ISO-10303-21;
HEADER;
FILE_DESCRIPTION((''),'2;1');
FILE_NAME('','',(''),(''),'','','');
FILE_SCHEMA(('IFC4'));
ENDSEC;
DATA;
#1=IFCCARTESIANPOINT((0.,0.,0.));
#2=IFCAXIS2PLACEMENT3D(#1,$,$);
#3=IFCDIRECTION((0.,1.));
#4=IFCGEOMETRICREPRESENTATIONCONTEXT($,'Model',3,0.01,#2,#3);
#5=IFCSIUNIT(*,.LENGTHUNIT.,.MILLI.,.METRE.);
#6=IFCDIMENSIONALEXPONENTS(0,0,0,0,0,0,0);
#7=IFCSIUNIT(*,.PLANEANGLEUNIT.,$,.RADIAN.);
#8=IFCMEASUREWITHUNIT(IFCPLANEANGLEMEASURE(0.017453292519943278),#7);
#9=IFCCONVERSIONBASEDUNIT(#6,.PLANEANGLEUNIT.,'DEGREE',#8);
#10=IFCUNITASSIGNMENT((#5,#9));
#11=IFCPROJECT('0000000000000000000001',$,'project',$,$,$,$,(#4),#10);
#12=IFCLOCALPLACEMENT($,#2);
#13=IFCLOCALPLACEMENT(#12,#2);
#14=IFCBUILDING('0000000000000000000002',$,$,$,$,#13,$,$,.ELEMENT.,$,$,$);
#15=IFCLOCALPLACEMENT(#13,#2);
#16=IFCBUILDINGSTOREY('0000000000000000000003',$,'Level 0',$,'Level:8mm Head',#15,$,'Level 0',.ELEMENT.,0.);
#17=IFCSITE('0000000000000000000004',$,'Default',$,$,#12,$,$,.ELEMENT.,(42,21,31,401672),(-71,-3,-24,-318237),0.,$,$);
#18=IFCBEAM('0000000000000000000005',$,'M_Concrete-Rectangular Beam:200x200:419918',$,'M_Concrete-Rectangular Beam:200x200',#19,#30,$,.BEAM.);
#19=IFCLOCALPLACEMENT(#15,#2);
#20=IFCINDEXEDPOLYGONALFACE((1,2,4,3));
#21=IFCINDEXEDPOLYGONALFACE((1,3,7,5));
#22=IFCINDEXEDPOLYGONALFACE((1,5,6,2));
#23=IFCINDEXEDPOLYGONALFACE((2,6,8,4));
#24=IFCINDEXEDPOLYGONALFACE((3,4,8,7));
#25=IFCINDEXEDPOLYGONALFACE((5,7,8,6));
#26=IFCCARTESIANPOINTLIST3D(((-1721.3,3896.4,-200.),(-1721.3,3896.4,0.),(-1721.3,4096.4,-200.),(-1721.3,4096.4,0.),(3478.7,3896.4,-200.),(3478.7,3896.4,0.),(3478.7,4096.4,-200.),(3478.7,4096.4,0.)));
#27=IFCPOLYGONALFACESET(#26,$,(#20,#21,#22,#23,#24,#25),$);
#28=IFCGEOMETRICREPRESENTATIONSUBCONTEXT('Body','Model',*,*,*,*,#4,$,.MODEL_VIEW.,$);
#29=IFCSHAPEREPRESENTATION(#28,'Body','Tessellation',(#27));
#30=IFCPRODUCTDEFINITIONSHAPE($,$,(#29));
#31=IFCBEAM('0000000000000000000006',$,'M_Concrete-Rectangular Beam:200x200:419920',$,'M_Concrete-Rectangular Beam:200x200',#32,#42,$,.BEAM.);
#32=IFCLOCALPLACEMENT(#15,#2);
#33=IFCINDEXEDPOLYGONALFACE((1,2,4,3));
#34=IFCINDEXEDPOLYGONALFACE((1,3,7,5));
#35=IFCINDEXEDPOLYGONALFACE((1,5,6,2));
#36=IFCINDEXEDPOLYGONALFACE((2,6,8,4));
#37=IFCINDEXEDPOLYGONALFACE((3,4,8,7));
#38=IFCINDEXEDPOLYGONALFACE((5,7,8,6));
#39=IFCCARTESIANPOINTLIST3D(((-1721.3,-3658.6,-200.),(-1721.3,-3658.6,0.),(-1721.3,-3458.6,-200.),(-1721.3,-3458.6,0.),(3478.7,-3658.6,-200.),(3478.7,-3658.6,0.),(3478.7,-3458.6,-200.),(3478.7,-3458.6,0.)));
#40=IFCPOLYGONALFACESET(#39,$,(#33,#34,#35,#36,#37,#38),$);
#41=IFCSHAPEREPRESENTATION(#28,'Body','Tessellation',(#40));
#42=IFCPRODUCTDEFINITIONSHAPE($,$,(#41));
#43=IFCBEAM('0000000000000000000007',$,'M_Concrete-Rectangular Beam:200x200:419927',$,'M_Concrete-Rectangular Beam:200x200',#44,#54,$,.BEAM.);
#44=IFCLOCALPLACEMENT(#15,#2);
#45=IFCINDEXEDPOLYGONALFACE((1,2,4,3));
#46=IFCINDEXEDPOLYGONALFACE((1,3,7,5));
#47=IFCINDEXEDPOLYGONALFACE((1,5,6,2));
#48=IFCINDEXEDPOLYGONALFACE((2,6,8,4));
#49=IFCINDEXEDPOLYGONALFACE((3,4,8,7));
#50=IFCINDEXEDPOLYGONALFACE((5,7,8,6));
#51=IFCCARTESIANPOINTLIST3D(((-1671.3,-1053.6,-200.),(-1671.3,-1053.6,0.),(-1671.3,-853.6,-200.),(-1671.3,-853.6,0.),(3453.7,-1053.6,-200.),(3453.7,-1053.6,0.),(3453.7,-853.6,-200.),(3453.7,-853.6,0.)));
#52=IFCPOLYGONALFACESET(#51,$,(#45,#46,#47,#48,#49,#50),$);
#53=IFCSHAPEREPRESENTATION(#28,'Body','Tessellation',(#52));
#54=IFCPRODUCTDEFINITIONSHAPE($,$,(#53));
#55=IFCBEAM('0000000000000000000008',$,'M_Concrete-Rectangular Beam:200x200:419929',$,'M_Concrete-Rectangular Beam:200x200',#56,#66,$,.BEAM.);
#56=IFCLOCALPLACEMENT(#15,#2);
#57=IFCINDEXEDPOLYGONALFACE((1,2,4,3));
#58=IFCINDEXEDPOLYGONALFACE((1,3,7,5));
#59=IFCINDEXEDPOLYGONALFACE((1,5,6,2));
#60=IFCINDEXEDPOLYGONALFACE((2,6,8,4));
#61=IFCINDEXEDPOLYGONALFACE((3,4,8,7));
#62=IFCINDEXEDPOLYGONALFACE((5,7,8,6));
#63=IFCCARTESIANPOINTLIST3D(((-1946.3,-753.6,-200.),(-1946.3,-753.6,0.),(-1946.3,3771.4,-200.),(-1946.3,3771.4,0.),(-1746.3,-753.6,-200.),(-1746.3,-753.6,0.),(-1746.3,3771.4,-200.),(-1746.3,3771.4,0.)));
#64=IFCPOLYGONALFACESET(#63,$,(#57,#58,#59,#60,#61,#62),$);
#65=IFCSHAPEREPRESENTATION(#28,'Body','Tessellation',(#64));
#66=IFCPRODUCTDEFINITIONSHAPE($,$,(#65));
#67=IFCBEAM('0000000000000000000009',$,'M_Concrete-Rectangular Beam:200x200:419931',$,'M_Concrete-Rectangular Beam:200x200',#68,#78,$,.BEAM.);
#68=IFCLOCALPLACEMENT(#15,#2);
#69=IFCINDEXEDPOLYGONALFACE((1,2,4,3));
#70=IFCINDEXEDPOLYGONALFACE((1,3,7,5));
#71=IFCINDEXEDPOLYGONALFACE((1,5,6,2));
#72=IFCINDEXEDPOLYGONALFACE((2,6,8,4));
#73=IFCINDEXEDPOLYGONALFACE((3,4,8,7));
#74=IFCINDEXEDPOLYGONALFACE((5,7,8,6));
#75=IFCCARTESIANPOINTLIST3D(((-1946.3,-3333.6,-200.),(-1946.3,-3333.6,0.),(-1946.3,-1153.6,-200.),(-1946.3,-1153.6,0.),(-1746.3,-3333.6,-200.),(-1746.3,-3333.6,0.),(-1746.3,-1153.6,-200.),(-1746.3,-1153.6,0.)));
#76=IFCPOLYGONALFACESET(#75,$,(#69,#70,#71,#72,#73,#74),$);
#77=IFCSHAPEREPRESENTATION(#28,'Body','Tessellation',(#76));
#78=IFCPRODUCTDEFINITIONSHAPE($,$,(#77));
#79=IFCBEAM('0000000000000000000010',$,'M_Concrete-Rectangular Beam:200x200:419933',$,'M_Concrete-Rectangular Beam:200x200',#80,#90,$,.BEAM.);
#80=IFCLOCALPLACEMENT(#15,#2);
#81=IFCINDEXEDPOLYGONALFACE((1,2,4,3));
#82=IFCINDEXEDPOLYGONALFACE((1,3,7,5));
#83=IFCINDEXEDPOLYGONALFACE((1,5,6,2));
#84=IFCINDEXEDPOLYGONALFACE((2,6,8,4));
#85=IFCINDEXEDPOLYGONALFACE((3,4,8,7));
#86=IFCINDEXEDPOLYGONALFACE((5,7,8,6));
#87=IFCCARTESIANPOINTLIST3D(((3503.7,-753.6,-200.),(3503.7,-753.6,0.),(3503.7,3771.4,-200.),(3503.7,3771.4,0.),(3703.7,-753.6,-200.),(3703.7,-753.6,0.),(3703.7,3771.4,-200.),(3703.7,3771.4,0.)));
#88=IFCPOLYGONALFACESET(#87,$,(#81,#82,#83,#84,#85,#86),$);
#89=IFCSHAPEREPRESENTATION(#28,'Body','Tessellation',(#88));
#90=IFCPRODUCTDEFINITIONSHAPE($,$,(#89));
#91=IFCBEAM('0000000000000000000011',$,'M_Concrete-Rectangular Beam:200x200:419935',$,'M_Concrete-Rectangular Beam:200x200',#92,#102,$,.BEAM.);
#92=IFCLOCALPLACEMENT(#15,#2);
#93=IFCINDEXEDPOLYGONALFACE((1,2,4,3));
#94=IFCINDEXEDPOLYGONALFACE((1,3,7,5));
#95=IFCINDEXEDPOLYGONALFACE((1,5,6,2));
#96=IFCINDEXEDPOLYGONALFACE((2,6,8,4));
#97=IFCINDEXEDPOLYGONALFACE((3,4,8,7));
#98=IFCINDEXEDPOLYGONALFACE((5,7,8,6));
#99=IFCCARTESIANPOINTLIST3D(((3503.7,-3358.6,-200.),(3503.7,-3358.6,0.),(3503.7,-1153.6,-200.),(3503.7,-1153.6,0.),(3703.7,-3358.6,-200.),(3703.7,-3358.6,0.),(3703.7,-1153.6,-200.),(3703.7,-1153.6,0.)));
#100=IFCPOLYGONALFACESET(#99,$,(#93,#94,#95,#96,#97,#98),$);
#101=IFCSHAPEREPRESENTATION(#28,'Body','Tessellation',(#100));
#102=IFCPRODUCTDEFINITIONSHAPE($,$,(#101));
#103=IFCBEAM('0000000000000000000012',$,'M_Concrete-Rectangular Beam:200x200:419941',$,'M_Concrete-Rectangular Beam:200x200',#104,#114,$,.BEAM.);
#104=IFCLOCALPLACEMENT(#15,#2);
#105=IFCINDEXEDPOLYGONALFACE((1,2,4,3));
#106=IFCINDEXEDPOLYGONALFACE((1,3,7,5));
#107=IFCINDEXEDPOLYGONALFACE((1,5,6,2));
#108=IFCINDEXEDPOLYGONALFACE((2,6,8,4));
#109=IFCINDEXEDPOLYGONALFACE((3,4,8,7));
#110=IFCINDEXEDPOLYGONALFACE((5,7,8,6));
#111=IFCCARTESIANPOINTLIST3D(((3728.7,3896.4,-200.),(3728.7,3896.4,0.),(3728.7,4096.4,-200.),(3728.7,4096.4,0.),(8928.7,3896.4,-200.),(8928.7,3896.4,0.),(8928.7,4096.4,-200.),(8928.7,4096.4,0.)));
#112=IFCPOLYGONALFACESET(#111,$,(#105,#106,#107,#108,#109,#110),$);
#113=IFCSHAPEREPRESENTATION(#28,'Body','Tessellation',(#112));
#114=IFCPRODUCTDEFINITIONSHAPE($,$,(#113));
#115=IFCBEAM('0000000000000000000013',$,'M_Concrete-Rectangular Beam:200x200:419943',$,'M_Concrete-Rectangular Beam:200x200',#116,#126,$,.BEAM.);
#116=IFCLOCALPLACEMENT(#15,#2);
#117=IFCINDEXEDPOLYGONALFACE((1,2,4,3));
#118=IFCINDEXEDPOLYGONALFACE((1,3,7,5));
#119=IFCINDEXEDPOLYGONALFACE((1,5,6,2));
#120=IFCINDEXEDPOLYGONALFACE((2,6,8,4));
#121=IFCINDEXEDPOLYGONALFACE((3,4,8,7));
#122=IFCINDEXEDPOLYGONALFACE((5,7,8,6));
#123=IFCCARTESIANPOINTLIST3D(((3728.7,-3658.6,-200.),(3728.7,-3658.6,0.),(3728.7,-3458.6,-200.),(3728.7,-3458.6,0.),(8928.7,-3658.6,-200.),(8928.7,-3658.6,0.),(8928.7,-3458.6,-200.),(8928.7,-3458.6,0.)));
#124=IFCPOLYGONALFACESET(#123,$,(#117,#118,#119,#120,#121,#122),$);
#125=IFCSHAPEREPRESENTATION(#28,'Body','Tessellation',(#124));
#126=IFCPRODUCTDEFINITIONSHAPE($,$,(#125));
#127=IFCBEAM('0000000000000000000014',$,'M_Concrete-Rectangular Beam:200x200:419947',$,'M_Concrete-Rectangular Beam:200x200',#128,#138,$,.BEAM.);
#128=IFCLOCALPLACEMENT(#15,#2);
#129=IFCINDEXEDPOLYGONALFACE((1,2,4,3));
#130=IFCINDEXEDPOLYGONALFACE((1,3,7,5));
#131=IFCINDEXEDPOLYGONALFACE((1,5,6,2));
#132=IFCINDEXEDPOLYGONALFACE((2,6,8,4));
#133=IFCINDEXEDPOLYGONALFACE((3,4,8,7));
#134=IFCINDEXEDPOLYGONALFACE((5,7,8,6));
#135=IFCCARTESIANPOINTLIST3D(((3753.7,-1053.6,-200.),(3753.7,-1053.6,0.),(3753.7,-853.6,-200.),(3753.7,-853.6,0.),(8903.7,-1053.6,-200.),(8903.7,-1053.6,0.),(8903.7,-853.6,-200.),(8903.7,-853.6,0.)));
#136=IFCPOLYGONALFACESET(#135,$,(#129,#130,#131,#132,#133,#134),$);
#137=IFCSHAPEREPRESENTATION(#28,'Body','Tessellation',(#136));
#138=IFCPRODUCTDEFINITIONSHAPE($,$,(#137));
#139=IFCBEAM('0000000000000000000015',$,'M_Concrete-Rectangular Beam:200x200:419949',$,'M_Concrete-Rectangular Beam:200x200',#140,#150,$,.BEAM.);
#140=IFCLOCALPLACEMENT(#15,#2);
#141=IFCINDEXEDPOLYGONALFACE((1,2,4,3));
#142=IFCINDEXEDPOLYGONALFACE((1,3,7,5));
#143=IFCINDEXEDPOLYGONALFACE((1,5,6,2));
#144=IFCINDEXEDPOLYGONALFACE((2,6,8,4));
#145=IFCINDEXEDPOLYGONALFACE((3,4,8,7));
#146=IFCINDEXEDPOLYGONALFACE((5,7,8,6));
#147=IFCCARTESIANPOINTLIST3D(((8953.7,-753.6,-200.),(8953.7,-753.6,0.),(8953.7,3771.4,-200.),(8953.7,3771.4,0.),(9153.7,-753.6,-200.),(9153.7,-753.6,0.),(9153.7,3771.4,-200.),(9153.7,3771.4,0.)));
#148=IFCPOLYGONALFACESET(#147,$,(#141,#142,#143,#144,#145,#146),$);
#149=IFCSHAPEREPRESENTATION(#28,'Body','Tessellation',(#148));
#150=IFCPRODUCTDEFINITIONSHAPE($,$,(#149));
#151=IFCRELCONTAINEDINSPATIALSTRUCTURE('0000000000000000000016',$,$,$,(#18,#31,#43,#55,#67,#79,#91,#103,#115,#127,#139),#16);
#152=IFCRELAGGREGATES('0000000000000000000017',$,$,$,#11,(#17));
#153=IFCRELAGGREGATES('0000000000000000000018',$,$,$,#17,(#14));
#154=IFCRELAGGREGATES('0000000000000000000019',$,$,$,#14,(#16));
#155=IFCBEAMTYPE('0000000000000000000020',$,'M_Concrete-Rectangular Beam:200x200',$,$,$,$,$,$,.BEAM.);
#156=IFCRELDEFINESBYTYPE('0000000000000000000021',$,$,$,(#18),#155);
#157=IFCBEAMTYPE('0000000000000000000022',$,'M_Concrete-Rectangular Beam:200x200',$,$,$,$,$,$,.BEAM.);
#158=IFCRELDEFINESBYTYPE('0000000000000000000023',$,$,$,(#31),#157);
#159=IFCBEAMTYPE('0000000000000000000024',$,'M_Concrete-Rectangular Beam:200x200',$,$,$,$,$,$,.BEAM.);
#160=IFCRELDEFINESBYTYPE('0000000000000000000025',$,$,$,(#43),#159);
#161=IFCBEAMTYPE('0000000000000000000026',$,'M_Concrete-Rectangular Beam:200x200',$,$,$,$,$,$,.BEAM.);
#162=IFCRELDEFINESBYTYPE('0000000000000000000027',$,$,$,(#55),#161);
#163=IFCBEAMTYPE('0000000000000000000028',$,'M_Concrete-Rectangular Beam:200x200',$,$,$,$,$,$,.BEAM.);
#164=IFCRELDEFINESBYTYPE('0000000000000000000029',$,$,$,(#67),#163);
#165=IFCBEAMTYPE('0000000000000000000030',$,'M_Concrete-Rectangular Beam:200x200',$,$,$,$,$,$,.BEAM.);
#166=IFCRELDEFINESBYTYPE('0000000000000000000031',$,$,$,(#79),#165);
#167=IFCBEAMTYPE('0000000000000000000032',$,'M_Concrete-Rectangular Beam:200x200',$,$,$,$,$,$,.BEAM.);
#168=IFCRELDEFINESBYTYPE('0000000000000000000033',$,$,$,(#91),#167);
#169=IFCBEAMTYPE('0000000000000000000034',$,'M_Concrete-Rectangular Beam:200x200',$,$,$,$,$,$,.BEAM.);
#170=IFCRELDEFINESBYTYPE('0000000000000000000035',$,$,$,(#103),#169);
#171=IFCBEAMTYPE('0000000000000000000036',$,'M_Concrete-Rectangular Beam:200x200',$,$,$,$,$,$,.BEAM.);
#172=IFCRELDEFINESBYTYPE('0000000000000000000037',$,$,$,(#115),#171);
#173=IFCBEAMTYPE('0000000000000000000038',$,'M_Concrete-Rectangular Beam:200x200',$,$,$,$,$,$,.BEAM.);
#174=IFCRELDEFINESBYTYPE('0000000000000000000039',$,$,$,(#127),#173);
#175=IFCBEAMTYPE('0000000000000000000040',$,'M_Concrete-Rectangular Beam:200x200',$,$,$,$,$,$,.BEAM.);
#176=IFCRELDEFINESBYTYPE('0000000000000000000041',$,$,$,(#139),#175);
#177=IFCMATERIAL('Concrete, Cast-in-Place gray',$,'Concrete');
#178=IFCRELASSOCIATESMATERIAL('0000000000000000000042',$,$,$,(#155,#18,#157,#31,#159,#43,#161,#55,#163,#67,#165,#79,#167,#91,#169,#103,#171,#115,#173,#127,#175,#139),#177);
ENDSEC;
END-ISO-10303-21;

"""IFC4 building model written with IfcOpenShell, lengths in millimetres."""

from ifc_helpers import new_model, entity, si_unit, converted_unit, direction, frame, origin, place, context, subcontext, project, spatial, indexed_curve, outline, extrude, source, transform, mapped, material, type_object, type_shapes, element, save


model = new_model("IFC4")

# Units and contexts
model_context = context("Model", 3, precision=0.01, world=origin(), true_north=direction((0.0, 1.0)))
body_context = subcontext(model_context, "Body", "Model", "MODEL_VIEW")
ifc_project = project(units=[si_unit("LENGTHUNIT", "METRE", prefix="MILLI"), converted_unit("PLANEANGLEUNIT", "DEGREE", entity("IfcPlaneAngleMeasure", 0.017453292519943278), si_unit("PLANEANGLEUNIT", "RADIAN"), dimensions=[0, 0, 0, 0, 0, 0, 0])], contexts=[model_context])

# Site, building, storey
site_placement = place(None, origin())
site = spatial("IfcSite", under=ifc_project, at=site_placement, Name="Default", CompositionType="ELEMENT", RefLatitude=(42, 21, 31, 401672), RefLongitude=(-71, -3, -24, -318237), RefElevation=0.0)
building_placement = place(site_placement, origin())
building = spatial("IfcBuilding", under=site, at=building_placement, CompositionType="ELEMENT")
storey_placement = place(building_placement, origin())
storey = spatial("IfcBuildingStorey", under=building, at=storey_placement, Name="Level 0", ObjectType="Level:8mm Head", LongName="Level 0", CompositionType="ELEMENT", Elevation=0.0)

# Beams
ifc_material = material(Name="Concrete, Cast-in-Place gray", Category="Concrete")
beam_type_1 = type_object("IfcBeamType", Name="M_Concrete-Rectangular Beam:200x200", PredefinedType="BEAM", material=ifc_material)
shared_shape_1 = source(origin(), body_context, "Body", "SweptSolid", [
    extrude(outline(indexed_curve([(-100.0, -100.0), (100.0, -100.0), (100.0, 100.0), (-100.0, 100.0), (-100.0, -100.0)], self_intersect=False)), frame((-1721.3, 3996.4, -100.0), z_axis=(1.0, 0.0, 0.0), x_axis=(0.0, 0.0, -1.0)), (0.0, 0.0, 1.0), 5200.0),
])
type_shapes(beam_type_1, [shared_shape_1])
beam_1_placement = place(storey_placement, origin())
element("IfcBeam", 1, at=beam_1_placement, inside=storey, type_object=beam_type_1, material=ifc_material, Name="M_Concrete-Rectangular Beam:200x200:419918", ObjectType="M_Concrete-Rectangular Beam:200x200", PredefinedType="BEAM", context=body_context, shape_type="MappedRepresentation", body=[
    mapped(shared_shape_1, transform((0.0, 0.0, 0.0), scale=1.0)),
])
beam_type_2 = type_object("IfcBeamType", Name="M_Concrete-Rectangular Beam:200x200", PredefinedType="BEAM", material=ifc_material)
shared_shape_2 = source(origin(), body_context, "Body", "SweptSolid", [
    extrude(outline(indexed_curve([(-100.0, -100.0), (100.0, -100.0), (100.0, 100.0), (-100.0, 100.0), (-100.0, -100.0)], self_intersect=False)), frame((-1721.3, -3558.6, -100.0), z_axis=(1.0, 0.0, 0.0), x_axis=(0.0, 0.0, -1.0)), (0.0, 0.0, 1.0), 5200.0),
])
type_shapes(beam_type_2, [shared_shape_2])
beam_2_placement = place(storey_placement, origin())
element("IfcBeam", 2, at=beam_2_placement, inside=storey, type_object=beam_type_2, material=ifc_material, Name="M_Concrete-Rectangular Beam:200x200:419920", ObjectType="M_Concrete-Rectangular Beam:200x200", PredefinedType="BEAM", context=body_context, shape_type="MappedRepresentation", body=[
    mapped(shared_shape_2, transform((0.0, 0.0, 0.0), scale=1.0)),
])
beam_type_3 = type_object("IfcBeamType", Name="M_Concrete-Rectangular Beam:200x200", PredefinedType="BEAM", material=ifc_material)
shared_shape_3 = source(origin(), body_context, "Body", "SweptSolid", [
    extrude(outline(indexed_curve([(-100.0, -100.0), (100.0, -100.0), (100.0, 100.0), (-100.0, 100.0), (-100.0, -100.0)], self_intersect=False)), frame((-1671.3, -953.6, -100.0), z_axis=(1.0, 0.0, 0.0), x_axis=(0.0, 0.0, -1.0)), (0.0, 0.0, 1.0), 5125.0),
])
type_shapes(beam_type_3, [shared_shape_3])
beam_3_placement = place(storey_placement, origin())
element("IfcBeam", 3, at=beam_3_placement, inside=storey, type_object=beam_type_3, material=ifc_material, Name="M_Concrete-Rectangular Beam:200x200:419927", ObjectType="M_Concrete-Rectangular Beam:200x200", PredefinedType="BEAM", context=body_context, shape_type="MappedRepresentation", body=[
    mapped(shared_shape_3, transform((0.0, 0.0, 0.0), scale=1.0)),
])
beam_type_4 = type_object("IfcBeamType", Name="M_Concrete-Rectangular Beam:200x200", PredefinedType="BEAM", material=ifc_material)
shared_shape_4 = source(origin(), body_context, "Body", "SweptSolid", [
    extrude(outline(indexed_curve([(-100.0, -100.0), (100.0, -100.0), (100.0, 100.0), (-100.0, 100.0), (-100.0, -100.0)], self_intersect=False)), frame((-1846.3, 3771.4, -100.0), z_axis=(0.0, -1.0, 0.0), x_axis=(-1.0, 0.0, 0.0)), (0.0, 0.0, 1.0), 4525.0),
])
type_shapes(beam_type_4, [shared_shape_4])
beam_4_placement = place(storey_placement, origin())
element("IfcBeam", 4, at=beam_4_placement, inside=storey, type_object=beam_type_4, material=ifc_material, Name="M_Concrete-Rectangular Beam:200x200:419929", ObjectType="M_Concrete-Rectangular Beam:200x200", PredefinedType="BEAM", context=body_context, shape_type="MappedRepresentation", body=[
    mapped(shared_shape_4, transform((0.0, 0.0, 0.0), scale=1.0)),
])
beam_type_5 = type_object("IfcBeamType", Name="M_Concrete-Rectangular Beam:200x200", PredefinedType="BEAM", material=ifc_material)
shared_shape_5 = source(origin(), body_context, "Body", "SweptSolid", [
    extrude(outline(indexed_curve([(-100.0, -100.0), (100.0, -100.0), (100.0, 100.0), (-100.0, 100.0), (-100.0, -100.0)], self_intersect=False)), frame((-1846.3, -1153.6, -100.0), z_axis=(0.0, -1.0, 0.0), x_axis=(-1.0, 0.0, 0.0)), (0.0, 0.0, 1.0), 2180.0),
])
type_shapes(beam_type_5, [shared_shape_5])
beam_5_placement = place(storey_placement, origin())
element("IfcBeam", 5, at=beam_5_placement, inside=storey, type_object=beam_type_5, material=ifc_material, Name="M_Concrete-Rectangular Beam:200x200:419931", ObjectType="M_Concrete-Rectangular Beam:200x200", PredefinedType="BEAM", context=body_context, shape_type="MappedRepresentation", body=[
    mapped(shared_shape_5, transform((0.0, 0.0, 0.0), scale=1.0)),
])
beam_type_6 = type_object("IfcBeamType", Name="M_Concrete-Rectangular Beam:200x200", PredefinedType="BEAM", material=ifc_material)
shared_shape_6 = source(origin(), body_context, "Body", "SweptSolid", [
    extrude(outline(indexed_curve([(-100.0, -100.0), (100.0, -100.0), (100.0, 100.0), (-100.0, 100.0), (-100.0, -100.0)], self_intersect=False)), frame((3603.7, 3771.4, -100.0), z_axis=(0.0, -1.0, 0.0), x_axis=(-1.0, 0.0, 0.0)), (0.0, 0.0, 1.0), 4525.0),
])
type_shapes(beam_type_6, [shared_shape_6])
beam_6_placement = place(storey_placement, origin())
element("IfcBeam", 6, at=beam_6_placement, inside=storey, type_object=beam_type_6, material=ifc_material, Name="M_Concrete-Rectangular Beam:200x200:419933", ObjectType="M_Concrete-Rectangular Beam:200x200", PredefinedType="BEAM", context=body_context, shape_type="MappedRepresentation", body=[
    mapped(shared_shape_6, transform((0.0, 0.0, 0.0), scale=1.0)),
])
beam_type_7 = type_object("IfcBeamType", Name="M_Concrete-Rectangular Beam:200x200", PredefinedType="BEAM", material=ifc_material)
shared_shape_7 = source(origin(), body_context, "Body", "SweptSolid", [
    extrude(outline(indexed_curve([(-100.0, -100.0), (100.0, -100.0), (100.0, 100.0), (-100.0, 100.0), (-100.0, -100.0)], self_intersect=False)), frame((3603.7, -1153.6, -100.0), z_axis=(0.0, -1.0, 0.0), x_axis=(-1.0, 0.0, 0.0)), (0.0, 0.0, 1.0), 2205.0),
])
type_shapes(beam_type_7, [shared_shape_7])
beam_7_placement = place(storey_placement, origin())
element("IfcBeam", 7, at=beam_7_placement, inside=storey, type_object=beam_type_7, material=ifc_material, Name="M_Concrete-Rectangular Beam:200x200:419935", ObjectType="M_Concrete-Rectangular Beam:200x200", PredefinedType="BEAM", context=body_context, shape_type="MappedRepresentation", body=[
    mapped(shared_shape_7, transform((0.0, 0.0, 0.0), scale=1.0)),
])
beam_type_8 = type_object("IfcBeamType", Name="M_Concrete-Rectangular Beam:200x200", PredefinedType="BEAM", material=ifc_material)
shared_shape_8 = source(origin(), body_context, "Body", "SweptSolid", [
    extrude(outline(indexed_curve([(-100.0, -100.0), (100.0, -100.0), (100.0, 100.0), (-100.0, 100.0), (-100.0, -100.0)], self_intersect=False)), frame((3728.7, 3996.4, -100.0), z_axis=(1.0, 0.0, 0.0), x_axis=(0.0, 0.0, -1.0)), (0.0, 0.0, 1.0), 5200.0),
])
type_shapes(beam_type_8, [shared_shape_8])
beam_8_placement = place(storey_placement, origin())
element("IfcBeam", 8, at=beam_8_placement, inside=storey, type_object=beam_type_8, material=ifc_material, Name="M_Concrete-Rectangular Beam:200x200:419941", ObjectType="M_Concrete-Rectangular Beam:200x200", PredefinedType="BEAM", context=body_context, shape_type="MappedRepresentation", body=[
    mapped(shared_shape_8, transform((0.0, 0.0, 0.0), scale=1.0)),
])
beam_type_9 = type_object("IfcBeamType", Name="M_Concrete-Rectangular Beam:200x200", PredefinedType="BEAM", material=ifc_material)
shared_shape_9 = source(origin(), body_context, "Body", "SweptSolid", [
    extrude(outline(indexed_curve([(-100.0, -100.0), (100.0, -100.0), (100.0, 100.0), (-100.0, 100.0), (-100.0, -100.0)], self_intersect=False)), frame((3728.7, -3558.6, -100.0), z_axis=(1.0, 0.0, 0.0), x_axis=(0.0, 0.0, -1.0)), (0.0, 0.0, 1.0), 5200.0),
])
type_shapes(beam_type_9, [shared_shape_9])
beam_9_placement = place(storey_placement, origin())
element("IfcBeam", 9, at=beam_9_placement, inside=storey, type_object=beam_type_9, material=ifc_material, Name="M_Concrete-Rectangular Beam:200x200:419943", ObjectType="M_Concrete-Rectangular Beam:200x200", PredefinedType="BEAM", context=body_context, shape_type="MappedRepresentation", body=[
    mapped(shared_shape_9, transform((0.0, 0.0, 0.0), scale=1.0)),
])
beam_type_10 = type_object("IfcBeamType", Name="M_Concrete-Rectangular Beam:200x200", PredefinedType="BEAM", material=ifc_material)
shared_shape_10 = source(origin(), body_context, "Body", "SweptSolid", [
    extrude(outline(indexed_curve([(-100.0, -100.0), (100.0, -100.0), (100.0, 100.0), (-100.0, 100.0), (-100.0, -100.0)], self_intersect=False)), frame((3753.7, -953.6, -100.0), z_axis=(1.0, 0.0, 0.0), x_axis=(0.0, 0.0, -1.0)), (0.0, 0.0, 1.0), 5150.0),
])
type_shapes(beam_type_10, [shared_shape_10])
beam_10_placement = place(storey_placement, origin())
element("IfcBeam", 10, at=beam_10_placement, inside=storey, type_object=beam_type_10, material=ifc_material, Name="M_Concrete-Rectangular Beam:200x200:419947", ObjectType="M_Concrete-Rectangular Beam:200x200", PredefinedType="BEAM", context=body_context, shape_type="MappedRepresentation", body=[
    mapped(shared_shape_10, transform((0.0, 0.0, 0.0), scale=1.0)),
])
beam_type_11 = type_object("IfcBeamType", Name="M_Concrete-Rectangular Beam:200x200", PredefinedType="BEAM", material=ifc_material)
shared_shape_11 = source(origin(), body_context, "Body", "SweptSolid", [
    extrude(outline(indexed_curve([(-100.0, -100.0), (100.0, -100.0), (100.0, 100.0), (-100.0, 100.0), (-100.0, -100.0)], self_intersect=False)), frame((9053.7, 3771.4, -100.0), z_axis=(0.0, -1.0, 0.0), x_axis=(-1.0, 0.0, 0.0)), (0.0, 0.0, 1.0), 4525.0),
])
type_shapes(beam_type_11, [shared_shape_11])
beam_11_placement = place(storey_placement, origin())
element("IfcBeam", 11, at=beam_11_placement, inside=storey, type_object=beam_type_11, material=ifc_material, Name="M_Concrete-Rectangular Beam:200x200:419949", ObjectType="M_Concrete-Rectangular Beam:200x200", PredefinedType="BEAM", context=body_context, shape_type="MappedRepresentation", body=[
    mapped(shared_shape_11, transform((0.0, 0.0, 0.0), scale=1.0)),
])

save(model, "model.ifc")
